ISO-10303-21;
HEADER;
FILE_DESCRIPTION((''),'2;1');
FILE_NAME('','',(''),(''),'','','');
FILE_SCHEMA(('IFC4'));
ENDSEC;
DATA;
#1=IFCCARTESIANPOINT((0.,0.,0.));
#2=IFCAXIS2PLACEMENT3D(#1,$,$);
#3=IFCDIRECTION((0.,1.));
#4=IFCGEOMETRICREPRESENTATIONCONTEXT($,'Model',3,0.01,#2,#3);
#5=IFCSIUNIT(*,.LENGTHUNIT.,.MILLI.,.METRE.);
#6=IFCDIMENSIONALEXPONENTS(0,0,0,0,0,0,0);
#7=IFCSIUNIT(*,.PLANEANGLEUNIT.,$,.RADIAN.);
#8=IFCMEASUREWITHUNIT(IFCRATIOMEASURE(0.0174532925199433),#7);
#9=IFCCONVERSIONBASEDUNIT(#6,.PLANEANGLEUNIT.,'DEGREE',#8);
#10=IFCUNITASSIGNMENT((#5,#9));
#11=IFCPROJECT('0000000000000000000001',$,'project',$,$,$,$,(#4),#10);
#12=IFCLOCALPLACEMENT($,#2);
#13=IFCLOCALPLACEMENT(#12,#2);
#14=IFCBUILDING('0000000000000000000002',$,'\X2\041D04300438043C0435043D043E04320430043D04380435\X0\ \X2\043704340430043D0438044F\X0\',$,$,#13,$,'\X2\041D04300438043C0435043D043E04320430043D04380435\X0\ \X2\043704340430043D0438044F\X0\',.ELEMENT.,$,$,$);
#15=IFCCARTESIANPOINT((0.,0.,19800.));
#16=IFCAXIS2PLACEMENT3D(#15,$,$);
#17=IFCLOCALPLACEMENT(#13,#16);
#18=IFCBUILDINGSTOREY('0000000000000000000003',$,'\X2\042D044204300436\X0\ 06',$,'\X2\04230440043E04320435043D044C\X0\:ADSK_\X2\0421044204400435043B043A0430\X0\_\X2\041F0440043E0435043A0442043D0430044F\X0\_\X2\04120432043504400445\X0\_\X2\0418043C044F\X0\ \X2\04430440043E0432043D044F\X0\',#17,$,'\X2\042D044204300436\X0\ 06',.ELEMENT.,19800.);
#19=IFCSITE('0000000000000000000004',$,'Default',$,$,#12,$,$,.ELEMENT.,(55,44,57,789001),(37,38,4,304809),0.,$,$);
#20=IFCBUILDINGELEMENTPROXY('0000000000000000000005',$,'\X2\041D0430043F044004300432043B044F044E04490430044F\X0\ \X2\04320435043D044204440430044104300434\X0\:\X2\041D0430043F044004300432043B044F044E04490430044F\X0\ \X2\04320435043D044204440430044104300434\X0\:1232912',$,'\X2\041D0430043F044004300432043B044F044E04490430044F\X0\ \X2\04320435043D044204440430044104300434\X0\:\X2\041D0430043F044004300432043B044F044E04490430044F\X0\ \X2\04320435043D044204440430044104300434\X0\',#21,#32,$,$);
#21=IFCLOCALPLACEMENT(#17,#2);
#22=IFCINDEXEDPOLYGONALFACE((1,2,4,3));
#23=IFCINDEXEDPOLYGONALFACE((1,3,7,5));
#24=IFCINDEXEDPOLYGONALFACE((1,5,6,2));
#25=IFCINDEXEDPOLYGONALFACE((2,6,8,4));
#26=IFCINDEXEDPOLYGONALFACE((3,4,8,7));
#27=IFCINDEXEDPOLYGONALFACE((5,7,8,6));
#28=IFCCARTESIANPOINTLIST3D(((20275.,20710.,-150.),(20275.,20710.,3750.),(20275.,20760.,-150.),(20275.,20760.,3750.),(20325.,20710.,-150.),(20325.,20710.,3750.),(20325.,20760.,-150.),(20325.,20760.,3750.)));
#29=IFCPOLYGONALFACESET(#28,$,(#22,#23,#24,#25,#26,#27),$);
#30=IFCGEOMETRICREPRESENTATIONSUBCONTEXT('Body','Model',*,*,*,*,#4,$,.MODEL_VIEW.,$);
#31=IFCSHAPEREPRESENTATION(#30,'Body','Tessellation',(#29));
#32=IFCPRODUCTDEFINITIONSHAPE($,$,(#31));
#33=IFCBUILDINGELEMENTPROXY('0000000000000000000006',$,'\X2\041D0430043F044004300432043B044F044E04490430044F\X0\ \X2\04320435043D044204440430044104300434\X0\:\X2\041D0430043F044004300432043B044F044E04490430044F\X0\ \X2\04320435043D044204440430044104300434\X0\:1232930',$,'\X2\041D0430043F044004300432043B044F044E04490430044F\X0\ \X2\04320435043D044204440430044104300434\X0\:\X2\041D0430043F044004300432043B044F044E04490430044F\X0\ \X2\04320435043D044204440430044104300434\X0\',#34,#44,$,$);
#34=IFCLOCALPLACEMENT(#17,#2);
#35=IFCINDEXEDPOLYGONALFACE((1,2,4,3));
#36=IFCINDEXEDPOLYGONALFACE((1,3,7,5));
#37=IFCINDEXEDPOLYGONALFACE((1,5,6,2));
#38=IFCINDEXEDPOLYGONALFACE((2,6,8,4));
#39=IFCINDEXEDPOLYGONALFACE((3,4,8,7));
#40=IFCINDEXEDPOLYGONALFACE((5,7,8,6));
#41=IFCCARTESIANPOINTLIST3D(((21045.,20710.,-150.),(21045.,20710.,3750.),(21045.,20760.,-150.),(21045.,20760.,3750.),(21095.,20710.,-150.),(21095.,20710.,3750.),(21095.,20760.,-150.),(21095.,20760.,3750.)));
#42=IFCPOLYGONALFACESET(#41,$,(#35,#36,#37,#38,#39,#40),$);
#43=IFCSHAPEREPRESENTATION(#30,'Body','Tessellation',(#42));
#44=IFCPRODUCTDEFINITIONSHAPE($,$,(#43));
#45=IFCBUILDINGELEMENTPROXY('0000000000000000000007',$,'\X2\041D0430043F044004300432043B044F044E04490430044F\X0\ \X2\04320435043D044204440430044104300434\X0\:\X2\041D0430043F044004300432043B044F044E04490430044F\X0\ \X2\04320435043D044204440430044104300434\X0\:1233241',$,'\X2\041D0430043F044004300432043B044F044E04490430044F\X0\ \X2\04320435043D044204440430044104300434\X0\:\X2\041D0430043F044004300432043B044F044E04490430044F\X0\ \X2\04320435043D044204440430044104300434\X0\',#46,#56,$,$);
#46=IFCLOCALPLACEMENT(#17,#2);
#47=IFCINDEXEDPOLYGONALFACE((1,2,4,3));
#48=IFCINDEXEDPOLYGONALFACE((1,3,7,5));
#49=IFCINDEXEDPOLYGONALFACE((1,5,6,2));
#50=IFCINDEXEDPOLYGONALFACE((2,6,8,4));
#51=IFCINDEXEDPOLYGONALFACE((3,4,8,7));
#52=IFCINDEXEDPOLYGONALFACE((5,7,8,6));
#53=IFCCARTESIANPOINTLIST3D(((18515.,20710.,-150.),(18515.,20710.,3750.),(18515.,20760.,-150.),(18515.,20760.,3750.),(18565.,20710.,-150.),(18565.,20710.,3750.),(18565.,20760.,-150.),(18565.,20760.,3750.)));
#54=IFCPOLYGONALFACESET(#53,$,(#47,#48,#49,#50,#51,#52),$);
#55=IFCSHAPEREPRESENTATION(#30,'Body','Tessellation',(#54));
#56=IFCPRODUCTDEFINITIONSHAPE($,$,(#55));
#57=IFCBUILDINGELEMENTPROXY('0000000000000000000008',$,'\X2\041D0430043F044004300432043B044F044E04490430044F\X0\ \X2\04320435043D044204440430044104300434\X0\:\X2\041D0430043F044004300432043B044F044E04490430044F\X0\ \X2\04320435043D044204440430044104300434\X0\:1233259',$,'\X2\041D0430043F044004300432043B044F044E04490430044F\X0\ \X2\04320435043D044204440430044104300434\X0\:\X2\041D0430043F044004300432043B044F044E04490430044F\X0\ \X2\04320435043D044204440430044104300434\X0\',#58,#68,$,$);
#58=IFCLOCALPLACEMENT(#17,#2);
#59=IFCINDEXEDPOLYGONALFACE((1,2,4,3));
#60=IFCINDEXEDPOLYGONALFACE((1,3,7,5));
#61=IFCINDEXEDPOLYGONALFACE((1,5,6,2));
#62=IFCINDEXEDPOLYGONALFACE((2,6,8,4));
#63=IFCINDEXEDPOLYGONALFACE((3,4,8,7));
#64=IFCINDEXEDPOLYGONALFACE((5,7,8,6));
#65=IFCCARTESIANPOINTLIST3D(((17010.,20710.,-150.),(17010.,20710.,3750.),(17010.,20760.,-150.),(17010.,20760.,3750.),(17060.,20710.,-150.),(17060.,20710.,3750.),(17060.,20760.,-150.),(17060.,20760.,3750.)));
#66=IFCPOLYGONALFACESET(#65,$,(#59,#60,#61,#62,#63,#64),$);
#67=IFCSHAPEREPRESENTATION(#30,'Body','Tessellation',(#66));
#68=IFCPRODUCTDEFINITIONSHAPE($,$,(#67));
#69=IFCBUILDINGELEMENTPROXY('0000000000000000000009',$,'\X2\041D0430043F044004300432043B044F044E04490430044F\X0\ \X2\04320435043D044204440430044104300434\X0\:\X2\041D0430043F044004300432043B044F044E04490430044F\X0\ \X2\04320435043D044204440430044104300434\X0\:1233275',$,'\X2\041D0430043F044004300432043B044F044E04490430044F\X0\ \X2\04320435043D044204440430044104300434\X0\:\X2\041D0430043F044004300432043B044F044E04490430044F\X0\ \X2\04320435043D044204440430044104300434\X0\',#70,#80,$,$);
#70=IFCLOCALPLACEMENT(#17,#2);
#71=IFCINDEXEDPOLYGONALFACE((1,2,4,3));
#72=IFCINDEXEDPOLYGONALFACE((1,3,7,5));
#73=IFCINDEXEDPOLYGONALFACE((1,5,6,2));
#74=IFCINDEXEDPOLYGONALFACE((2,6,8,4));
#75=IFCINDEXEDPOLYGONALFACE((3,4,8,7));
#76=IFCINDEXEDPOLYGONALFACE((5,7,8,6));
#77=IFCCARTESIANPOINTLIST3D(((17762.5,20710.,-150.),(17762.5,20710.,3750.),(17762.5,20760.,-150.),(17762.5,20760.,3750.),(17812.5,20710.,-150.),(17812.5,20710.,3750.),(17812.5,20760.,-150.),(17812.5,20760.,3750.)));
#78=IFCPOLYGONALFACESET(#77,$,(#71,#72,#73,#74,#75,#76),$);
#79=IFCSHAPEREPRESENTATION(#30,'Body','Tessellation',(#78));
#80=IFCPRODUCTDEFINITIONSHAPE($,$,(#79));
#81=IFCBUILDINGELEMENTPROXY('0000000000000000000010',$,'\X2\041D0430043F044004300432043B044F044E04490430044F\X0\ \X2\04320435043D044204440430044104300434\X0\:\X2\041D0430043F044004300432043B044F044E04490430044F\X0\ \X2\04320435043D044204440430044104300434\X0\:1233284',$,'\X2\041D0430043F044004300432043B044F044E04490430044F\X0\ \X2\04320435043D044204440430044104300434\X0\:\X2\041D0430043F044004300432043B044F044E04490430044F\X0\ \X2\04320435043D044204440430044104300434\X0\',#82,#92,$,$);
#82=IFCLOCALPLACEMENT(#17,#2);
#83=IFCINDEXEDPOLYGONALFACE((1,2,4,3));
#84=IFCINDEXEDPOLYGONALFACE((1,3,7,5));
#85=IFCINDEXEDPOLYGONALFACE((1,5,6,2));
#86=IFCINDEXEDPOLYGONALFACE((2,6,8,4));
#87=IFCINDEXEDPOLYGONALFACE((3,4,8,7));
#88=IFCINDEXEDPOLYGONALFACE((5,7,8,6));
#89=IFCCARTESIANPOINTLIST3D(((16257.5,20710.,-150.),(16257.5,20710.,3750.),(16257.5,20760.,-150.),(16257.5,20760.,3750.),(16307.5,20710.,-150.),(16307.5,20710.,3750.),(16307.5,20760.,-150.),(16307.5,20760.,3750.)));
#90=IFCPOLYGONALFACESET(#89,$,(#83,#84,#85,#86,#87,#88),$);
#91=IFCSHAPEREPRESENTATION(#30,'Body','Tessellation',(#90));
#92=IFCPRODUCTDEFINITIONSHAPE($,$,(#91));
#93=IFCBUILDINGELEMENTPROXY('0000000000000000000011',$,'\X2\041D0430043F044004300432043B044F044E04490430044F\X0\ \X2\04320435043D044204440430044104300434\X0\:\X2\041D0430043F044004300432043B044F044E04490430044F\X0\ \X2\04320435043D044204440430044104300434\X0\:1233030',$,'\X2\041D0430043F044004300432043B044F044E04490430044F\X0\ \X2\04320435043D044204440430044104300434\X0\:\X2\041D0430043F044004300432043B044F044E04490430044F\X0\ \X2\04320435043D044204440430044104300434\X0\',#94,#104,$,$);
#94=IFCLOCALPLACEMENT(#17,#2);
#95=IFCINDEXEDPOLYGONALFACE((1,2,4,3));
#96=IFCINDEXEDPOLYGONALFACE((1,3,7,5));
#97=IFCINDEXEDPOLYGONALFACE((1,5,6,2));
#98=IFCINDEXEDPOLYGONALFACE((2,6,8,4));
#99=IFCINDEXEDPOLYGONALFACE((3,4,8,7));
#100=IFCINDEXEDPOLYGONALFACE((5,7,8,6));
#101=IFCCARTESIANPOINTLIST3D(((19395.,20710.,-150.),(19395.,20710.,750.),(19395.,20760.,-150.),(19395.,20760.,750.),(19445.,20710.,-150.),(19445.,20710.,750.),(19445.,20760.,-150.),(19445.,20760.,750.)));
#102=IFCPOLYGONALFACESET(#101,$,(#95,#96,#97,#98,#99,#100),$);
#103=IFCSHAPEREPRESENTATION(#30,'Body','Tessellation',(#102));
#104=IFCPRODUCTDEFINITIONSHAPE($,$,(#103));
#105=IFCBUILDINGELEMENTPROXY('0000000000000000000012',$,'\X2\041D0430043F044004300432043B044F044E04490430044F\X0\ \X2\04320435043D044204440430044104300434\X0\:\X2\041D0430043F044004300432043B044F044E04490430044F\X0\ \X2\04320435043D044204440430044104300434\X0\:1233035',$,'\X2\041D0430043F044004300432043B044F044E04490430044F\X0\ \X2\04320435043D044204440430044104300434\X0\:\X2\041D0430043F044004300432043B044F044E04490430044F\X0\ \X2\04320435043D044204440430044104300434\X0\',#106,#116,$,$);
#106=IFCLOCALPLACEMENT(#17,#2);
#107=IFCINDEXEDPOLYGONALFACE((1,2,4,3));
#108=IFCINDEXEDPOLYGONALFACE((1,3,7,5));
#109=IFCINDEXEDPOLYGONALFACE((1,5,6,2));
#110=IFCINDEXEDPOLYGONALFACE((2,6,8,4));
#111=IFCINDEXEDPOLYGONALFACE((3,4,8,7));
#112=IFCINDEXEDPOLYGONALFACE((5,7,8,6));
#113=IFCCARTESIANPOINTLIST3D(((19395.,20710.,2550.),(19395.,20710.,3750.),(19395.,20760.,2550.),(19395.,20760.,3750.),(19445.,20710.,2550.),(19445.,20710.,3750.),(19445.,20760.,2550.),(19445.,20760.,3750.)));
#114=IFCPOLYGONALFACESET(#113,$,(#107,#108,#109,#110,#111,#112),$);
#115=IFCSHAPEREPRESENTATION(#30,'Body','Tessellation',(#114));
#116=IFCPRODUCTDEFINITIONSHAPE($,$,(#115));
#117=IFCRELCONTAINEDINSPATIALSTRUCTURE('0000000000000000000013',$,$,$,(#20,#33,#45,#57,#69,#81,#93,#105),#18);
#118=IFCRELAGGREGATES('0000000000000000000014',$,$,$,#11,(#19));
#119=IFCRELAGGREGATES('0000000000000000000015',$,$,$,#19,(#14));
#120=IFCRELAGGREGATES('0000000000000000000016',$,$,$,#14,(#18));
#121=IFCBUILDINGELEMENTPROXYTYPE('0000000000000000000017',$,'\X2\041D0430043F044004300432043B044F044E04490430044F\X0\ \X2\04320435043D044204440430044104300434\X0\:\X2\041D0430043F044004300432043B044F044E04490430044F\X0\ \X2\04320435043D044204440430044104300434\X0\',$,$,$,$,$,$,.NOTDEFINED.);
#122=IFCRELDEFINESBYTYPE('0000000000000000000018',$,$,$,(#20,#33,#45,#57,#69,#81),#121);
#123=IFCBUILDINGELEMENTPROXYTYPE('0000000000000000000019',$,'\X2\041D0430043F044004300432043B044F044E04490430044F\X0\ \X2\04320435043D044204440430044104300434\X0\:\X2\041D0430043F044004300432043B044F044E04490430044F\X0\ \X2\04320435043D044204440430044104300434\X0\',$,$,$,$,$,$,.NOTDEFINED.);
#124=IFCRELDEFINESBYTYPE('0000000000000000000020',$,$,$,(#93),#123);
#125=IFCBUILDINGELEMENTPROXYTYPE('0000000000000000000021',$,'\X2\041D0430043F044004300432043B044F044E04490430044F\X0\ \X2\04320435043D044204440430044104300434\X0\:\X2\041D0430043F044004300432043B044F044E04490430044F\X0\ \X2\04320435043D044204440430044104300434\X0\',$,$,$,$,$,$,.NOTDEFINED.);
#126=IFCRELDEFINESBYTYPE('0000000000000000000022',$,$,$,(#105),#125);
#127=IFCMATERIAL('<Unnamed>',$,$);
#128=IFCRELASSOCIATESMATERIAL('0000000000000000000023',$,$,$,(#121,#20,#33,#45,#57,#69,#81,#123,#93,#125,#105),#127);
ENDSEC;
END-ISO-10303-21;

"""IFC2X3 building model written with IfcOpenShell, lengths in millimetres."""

from ifc_helpers import new_model, entity, si_unit, converted_unit, direction, frame, origin, origin_2d_with_axis, place, context, subcontext, project, spatial, rectangle, extrude, source, transform, mapped, material, type_object, type_shapes, element, save


model = new_model("IFC2X3")

# Units and contexts
model_context = context("Model", 3, precision=0.01, world=origin(), true_north=direction((0.0, 1.0)))
body_context = subcontext(model_context, "Body", "Model", "MODEL_VIEW")
ifc_project = project(units=[si_unit("LENGTHUNIT", "METRE", prefix="MILLI"), converted_unit("PLANEANGLEUNIT", "DEGREE", entity("IfcRatioMeasure", 0.0174532925199433), si_unit("PLANEANGLEUNIT", "RADIAN"), dimensions=[0, 0, 0, 0, 0, 0, 0])], contexts=[model_context])

# Site, building, storey
site_placement = place(None, origin())
site = spatial("IfcSite", under=ifc_project, at=site_placement, Name="Default", CompositionType="ELEMENT", RefLatitude=(55, 44, 57, 789001), RefLongitude=(37, 38, 4, 304809), RefElevation=0.0)
building_placement = place(site_placement, origin())
building = spatial("IfcBuilding", under=site, at=building_placement, Name="Наименование здания", LongName="Наименование здания", CompositionType="ELEMENT")
storey_placement = place(building_placement, frame((0.0, 0.0, 19800.0)))
storey = spatial("IfcBuildingStorey", under=building, at=storey_placement, Name="Этаж 06", ObjectType="Уровень:ADSK_Стрелка_Проектная_Вверх_Имя уровня", LongName="Этаж 06", CompositionType="ELEMENT", Elevation=19800.0)

# Building element proxies
ifc_material_1 = material(Name="<Unnamed>")
building_element_proxy_type_1 = type_object("IfcBuildingElementProxyType", Name="Направляющая вентфасад:Направляющая вентфасад", PredefinedType="NOTDEFINED", material=ifc_material_1)
shared_shape_1 = source(origin(), body_context, "Body", "SweptSolid", [
    extrude(rectangle(XDim=50.0, YDim=50.0, at=origin_2d_with_axis()), frame((25.0, -25.0, 0.0), z_axis=(0.0, 0.0, 1.0), x_axis=(-1.0, 0.0, 0.0)), (0.0, 0.0, 1.0), 3900.0),
])
type_shapes(building_element_proxy_type_1, [shared_shape_1])
for number, where, z_axis, x_axis, name in (
    (1, (20325.0, 20710.0, -150.0), (0.0, 0.0, 1.0), (-1.0, 0.0, 0.0), "Направляющая вентфасад:Направляющая вентфасад:1232912"),
    (2, (21095.0, 20710.0, -150.0), (0.0, 0.0, 1.0), (-1.0, 0.0, 0.0), "Направляющая вентфасад:Направляющая вентфасад:1232930"),
    (3, (18565.0, 20710.0, -150.0), (0.0, 0.0, 1.0), (-1.0, 0.0, 0.0), "Направляющая вентфасад:Направляющая вентфасад:1233241"),
    (4, (17060.0, 20710.0, -150.0), (0.0, 0.0, 1.0), (-1.0, 0.0, 0.0), "Направляющая вентфасад:Направляющая вентфасад:1233259"),
    (5, (17812.5, 20710.0, -150.0), (0.0, 0.0, 1.0), (-1.0, 0.0, 0.0), "Направляющая вентфасад:Направляющая вентфасад:1233275"),
    (6, (16307.5, 20710.0, -150.0), (0.0, 0.0, 1.0), (-1.0, 0.0, 0.0), "Направляющая вентфасад:Направляющая вентфасад:1233284"),
):
    element("IfcBuildingElementProxy", number, at=place(storey_placement, frame(where, z_axis=z_axis, x_axis=x_axis)), inside=storey, type_object=building_element_proxy_type_1, material=ifc_material_1, Name=name, ObjectType="Направляющая вентфасад:Направляющая вентфасад", context=body_context, shape_type="MappedRepresentation", body=[
        mapped(shared_shape_1, transform((0.0, 0.0, 0.0), scale=1.0)),
    ])
building_element_proxy_type_2 = type_object("IfcBuildingElementProxyType", Name="Направляющая вентфасад:Направляющая вентфасад", PredefinedType="NOTDEFINED", material=ifc_material_1)
shared_shape_2 = source(origin(), body_context, "Body", "SweptSolid", [
    extrude(rectangle(XDim=50.0, YDim=50.0, at=origin_2d_with_axis()), frame((25.0, -25.0, 0.0), z_axis=(0.0, 0.0, 1.0), x_axis=(-1.0, 0.0, 0.0)), (0.0, 0.0, 1.0), 900.0),
])
type_shapes(building_element_proxy_type_2, [shared_shape_2])
proxy_1_placement = place(storey_placement, frame((19445.0, 20710.0, -150.0), z_axis=(0.0, 0.0, 1.0), x_axis=(-1.0, 0.0, 0.0)))
element("IfcBuildingElementProxy", 7, at=proxy_1_placement, inside=storey, type_object=building_element_proxy_type_2, material=ifc_material_1, Name="Направляющая вентфасад:Направляющая вентфасад:1233030", ObjectType="Направляющая вентфасад:Направляющая вентфасад", context=body_context, shape_type="MappedRepresentation", body=[
    mapped(shared_shape_2, transform((0.0, 0.0, 0.0), scale=1.0)),
])
building_element_proxy_type_3 = type_object("IfcBuildingElementProxyType", Name="Направляющая вентфасад:Направляющая вентфасад", PredefinedType="NOTDEFINED", material=ifc_material_1)
shared_shape_3 = source(origin(), body_context, "Body", "SweptSolid", [
    extrude(rectangle(XDim=50.0, YDim=50.0, at=origin_2d_with_axis()), frame((25.0, -25.0, 0.0), z_axis=(0.0, 0.0, 1.0), x_axis=(-1.0, 0.0, 0.0)), (0.0, 0.0, 1.0), 1200.0),
])
type_shapes(building_element_proxy_type_3, [shared_shape_3])
proxy_2_placement = place(storey_placement, frame((19445.0, 20710.0, 2550.0), z_axis=(0.0, 0.0, 1.0), x_axis=(-1.0, 0.0, 0.0)))
element("IfcBuildingElementProxy", 8, at=proxy_2_placement, inside=storey, type_object=building_element_proxy_type_3, material=ifc_material_1, Name="Направляющая вентфасад:Направляющая вентфасад:1233035", ObjectType="Направляющая вентфасад:Направляющая вентфасад", context=body_context, shape_type="MappedRepresentation", body=[
    mapped(shared_shape_3, transform((0.0, 0.0, 0.0), scale=1.0)),
])

save(model, "model.ifc")
